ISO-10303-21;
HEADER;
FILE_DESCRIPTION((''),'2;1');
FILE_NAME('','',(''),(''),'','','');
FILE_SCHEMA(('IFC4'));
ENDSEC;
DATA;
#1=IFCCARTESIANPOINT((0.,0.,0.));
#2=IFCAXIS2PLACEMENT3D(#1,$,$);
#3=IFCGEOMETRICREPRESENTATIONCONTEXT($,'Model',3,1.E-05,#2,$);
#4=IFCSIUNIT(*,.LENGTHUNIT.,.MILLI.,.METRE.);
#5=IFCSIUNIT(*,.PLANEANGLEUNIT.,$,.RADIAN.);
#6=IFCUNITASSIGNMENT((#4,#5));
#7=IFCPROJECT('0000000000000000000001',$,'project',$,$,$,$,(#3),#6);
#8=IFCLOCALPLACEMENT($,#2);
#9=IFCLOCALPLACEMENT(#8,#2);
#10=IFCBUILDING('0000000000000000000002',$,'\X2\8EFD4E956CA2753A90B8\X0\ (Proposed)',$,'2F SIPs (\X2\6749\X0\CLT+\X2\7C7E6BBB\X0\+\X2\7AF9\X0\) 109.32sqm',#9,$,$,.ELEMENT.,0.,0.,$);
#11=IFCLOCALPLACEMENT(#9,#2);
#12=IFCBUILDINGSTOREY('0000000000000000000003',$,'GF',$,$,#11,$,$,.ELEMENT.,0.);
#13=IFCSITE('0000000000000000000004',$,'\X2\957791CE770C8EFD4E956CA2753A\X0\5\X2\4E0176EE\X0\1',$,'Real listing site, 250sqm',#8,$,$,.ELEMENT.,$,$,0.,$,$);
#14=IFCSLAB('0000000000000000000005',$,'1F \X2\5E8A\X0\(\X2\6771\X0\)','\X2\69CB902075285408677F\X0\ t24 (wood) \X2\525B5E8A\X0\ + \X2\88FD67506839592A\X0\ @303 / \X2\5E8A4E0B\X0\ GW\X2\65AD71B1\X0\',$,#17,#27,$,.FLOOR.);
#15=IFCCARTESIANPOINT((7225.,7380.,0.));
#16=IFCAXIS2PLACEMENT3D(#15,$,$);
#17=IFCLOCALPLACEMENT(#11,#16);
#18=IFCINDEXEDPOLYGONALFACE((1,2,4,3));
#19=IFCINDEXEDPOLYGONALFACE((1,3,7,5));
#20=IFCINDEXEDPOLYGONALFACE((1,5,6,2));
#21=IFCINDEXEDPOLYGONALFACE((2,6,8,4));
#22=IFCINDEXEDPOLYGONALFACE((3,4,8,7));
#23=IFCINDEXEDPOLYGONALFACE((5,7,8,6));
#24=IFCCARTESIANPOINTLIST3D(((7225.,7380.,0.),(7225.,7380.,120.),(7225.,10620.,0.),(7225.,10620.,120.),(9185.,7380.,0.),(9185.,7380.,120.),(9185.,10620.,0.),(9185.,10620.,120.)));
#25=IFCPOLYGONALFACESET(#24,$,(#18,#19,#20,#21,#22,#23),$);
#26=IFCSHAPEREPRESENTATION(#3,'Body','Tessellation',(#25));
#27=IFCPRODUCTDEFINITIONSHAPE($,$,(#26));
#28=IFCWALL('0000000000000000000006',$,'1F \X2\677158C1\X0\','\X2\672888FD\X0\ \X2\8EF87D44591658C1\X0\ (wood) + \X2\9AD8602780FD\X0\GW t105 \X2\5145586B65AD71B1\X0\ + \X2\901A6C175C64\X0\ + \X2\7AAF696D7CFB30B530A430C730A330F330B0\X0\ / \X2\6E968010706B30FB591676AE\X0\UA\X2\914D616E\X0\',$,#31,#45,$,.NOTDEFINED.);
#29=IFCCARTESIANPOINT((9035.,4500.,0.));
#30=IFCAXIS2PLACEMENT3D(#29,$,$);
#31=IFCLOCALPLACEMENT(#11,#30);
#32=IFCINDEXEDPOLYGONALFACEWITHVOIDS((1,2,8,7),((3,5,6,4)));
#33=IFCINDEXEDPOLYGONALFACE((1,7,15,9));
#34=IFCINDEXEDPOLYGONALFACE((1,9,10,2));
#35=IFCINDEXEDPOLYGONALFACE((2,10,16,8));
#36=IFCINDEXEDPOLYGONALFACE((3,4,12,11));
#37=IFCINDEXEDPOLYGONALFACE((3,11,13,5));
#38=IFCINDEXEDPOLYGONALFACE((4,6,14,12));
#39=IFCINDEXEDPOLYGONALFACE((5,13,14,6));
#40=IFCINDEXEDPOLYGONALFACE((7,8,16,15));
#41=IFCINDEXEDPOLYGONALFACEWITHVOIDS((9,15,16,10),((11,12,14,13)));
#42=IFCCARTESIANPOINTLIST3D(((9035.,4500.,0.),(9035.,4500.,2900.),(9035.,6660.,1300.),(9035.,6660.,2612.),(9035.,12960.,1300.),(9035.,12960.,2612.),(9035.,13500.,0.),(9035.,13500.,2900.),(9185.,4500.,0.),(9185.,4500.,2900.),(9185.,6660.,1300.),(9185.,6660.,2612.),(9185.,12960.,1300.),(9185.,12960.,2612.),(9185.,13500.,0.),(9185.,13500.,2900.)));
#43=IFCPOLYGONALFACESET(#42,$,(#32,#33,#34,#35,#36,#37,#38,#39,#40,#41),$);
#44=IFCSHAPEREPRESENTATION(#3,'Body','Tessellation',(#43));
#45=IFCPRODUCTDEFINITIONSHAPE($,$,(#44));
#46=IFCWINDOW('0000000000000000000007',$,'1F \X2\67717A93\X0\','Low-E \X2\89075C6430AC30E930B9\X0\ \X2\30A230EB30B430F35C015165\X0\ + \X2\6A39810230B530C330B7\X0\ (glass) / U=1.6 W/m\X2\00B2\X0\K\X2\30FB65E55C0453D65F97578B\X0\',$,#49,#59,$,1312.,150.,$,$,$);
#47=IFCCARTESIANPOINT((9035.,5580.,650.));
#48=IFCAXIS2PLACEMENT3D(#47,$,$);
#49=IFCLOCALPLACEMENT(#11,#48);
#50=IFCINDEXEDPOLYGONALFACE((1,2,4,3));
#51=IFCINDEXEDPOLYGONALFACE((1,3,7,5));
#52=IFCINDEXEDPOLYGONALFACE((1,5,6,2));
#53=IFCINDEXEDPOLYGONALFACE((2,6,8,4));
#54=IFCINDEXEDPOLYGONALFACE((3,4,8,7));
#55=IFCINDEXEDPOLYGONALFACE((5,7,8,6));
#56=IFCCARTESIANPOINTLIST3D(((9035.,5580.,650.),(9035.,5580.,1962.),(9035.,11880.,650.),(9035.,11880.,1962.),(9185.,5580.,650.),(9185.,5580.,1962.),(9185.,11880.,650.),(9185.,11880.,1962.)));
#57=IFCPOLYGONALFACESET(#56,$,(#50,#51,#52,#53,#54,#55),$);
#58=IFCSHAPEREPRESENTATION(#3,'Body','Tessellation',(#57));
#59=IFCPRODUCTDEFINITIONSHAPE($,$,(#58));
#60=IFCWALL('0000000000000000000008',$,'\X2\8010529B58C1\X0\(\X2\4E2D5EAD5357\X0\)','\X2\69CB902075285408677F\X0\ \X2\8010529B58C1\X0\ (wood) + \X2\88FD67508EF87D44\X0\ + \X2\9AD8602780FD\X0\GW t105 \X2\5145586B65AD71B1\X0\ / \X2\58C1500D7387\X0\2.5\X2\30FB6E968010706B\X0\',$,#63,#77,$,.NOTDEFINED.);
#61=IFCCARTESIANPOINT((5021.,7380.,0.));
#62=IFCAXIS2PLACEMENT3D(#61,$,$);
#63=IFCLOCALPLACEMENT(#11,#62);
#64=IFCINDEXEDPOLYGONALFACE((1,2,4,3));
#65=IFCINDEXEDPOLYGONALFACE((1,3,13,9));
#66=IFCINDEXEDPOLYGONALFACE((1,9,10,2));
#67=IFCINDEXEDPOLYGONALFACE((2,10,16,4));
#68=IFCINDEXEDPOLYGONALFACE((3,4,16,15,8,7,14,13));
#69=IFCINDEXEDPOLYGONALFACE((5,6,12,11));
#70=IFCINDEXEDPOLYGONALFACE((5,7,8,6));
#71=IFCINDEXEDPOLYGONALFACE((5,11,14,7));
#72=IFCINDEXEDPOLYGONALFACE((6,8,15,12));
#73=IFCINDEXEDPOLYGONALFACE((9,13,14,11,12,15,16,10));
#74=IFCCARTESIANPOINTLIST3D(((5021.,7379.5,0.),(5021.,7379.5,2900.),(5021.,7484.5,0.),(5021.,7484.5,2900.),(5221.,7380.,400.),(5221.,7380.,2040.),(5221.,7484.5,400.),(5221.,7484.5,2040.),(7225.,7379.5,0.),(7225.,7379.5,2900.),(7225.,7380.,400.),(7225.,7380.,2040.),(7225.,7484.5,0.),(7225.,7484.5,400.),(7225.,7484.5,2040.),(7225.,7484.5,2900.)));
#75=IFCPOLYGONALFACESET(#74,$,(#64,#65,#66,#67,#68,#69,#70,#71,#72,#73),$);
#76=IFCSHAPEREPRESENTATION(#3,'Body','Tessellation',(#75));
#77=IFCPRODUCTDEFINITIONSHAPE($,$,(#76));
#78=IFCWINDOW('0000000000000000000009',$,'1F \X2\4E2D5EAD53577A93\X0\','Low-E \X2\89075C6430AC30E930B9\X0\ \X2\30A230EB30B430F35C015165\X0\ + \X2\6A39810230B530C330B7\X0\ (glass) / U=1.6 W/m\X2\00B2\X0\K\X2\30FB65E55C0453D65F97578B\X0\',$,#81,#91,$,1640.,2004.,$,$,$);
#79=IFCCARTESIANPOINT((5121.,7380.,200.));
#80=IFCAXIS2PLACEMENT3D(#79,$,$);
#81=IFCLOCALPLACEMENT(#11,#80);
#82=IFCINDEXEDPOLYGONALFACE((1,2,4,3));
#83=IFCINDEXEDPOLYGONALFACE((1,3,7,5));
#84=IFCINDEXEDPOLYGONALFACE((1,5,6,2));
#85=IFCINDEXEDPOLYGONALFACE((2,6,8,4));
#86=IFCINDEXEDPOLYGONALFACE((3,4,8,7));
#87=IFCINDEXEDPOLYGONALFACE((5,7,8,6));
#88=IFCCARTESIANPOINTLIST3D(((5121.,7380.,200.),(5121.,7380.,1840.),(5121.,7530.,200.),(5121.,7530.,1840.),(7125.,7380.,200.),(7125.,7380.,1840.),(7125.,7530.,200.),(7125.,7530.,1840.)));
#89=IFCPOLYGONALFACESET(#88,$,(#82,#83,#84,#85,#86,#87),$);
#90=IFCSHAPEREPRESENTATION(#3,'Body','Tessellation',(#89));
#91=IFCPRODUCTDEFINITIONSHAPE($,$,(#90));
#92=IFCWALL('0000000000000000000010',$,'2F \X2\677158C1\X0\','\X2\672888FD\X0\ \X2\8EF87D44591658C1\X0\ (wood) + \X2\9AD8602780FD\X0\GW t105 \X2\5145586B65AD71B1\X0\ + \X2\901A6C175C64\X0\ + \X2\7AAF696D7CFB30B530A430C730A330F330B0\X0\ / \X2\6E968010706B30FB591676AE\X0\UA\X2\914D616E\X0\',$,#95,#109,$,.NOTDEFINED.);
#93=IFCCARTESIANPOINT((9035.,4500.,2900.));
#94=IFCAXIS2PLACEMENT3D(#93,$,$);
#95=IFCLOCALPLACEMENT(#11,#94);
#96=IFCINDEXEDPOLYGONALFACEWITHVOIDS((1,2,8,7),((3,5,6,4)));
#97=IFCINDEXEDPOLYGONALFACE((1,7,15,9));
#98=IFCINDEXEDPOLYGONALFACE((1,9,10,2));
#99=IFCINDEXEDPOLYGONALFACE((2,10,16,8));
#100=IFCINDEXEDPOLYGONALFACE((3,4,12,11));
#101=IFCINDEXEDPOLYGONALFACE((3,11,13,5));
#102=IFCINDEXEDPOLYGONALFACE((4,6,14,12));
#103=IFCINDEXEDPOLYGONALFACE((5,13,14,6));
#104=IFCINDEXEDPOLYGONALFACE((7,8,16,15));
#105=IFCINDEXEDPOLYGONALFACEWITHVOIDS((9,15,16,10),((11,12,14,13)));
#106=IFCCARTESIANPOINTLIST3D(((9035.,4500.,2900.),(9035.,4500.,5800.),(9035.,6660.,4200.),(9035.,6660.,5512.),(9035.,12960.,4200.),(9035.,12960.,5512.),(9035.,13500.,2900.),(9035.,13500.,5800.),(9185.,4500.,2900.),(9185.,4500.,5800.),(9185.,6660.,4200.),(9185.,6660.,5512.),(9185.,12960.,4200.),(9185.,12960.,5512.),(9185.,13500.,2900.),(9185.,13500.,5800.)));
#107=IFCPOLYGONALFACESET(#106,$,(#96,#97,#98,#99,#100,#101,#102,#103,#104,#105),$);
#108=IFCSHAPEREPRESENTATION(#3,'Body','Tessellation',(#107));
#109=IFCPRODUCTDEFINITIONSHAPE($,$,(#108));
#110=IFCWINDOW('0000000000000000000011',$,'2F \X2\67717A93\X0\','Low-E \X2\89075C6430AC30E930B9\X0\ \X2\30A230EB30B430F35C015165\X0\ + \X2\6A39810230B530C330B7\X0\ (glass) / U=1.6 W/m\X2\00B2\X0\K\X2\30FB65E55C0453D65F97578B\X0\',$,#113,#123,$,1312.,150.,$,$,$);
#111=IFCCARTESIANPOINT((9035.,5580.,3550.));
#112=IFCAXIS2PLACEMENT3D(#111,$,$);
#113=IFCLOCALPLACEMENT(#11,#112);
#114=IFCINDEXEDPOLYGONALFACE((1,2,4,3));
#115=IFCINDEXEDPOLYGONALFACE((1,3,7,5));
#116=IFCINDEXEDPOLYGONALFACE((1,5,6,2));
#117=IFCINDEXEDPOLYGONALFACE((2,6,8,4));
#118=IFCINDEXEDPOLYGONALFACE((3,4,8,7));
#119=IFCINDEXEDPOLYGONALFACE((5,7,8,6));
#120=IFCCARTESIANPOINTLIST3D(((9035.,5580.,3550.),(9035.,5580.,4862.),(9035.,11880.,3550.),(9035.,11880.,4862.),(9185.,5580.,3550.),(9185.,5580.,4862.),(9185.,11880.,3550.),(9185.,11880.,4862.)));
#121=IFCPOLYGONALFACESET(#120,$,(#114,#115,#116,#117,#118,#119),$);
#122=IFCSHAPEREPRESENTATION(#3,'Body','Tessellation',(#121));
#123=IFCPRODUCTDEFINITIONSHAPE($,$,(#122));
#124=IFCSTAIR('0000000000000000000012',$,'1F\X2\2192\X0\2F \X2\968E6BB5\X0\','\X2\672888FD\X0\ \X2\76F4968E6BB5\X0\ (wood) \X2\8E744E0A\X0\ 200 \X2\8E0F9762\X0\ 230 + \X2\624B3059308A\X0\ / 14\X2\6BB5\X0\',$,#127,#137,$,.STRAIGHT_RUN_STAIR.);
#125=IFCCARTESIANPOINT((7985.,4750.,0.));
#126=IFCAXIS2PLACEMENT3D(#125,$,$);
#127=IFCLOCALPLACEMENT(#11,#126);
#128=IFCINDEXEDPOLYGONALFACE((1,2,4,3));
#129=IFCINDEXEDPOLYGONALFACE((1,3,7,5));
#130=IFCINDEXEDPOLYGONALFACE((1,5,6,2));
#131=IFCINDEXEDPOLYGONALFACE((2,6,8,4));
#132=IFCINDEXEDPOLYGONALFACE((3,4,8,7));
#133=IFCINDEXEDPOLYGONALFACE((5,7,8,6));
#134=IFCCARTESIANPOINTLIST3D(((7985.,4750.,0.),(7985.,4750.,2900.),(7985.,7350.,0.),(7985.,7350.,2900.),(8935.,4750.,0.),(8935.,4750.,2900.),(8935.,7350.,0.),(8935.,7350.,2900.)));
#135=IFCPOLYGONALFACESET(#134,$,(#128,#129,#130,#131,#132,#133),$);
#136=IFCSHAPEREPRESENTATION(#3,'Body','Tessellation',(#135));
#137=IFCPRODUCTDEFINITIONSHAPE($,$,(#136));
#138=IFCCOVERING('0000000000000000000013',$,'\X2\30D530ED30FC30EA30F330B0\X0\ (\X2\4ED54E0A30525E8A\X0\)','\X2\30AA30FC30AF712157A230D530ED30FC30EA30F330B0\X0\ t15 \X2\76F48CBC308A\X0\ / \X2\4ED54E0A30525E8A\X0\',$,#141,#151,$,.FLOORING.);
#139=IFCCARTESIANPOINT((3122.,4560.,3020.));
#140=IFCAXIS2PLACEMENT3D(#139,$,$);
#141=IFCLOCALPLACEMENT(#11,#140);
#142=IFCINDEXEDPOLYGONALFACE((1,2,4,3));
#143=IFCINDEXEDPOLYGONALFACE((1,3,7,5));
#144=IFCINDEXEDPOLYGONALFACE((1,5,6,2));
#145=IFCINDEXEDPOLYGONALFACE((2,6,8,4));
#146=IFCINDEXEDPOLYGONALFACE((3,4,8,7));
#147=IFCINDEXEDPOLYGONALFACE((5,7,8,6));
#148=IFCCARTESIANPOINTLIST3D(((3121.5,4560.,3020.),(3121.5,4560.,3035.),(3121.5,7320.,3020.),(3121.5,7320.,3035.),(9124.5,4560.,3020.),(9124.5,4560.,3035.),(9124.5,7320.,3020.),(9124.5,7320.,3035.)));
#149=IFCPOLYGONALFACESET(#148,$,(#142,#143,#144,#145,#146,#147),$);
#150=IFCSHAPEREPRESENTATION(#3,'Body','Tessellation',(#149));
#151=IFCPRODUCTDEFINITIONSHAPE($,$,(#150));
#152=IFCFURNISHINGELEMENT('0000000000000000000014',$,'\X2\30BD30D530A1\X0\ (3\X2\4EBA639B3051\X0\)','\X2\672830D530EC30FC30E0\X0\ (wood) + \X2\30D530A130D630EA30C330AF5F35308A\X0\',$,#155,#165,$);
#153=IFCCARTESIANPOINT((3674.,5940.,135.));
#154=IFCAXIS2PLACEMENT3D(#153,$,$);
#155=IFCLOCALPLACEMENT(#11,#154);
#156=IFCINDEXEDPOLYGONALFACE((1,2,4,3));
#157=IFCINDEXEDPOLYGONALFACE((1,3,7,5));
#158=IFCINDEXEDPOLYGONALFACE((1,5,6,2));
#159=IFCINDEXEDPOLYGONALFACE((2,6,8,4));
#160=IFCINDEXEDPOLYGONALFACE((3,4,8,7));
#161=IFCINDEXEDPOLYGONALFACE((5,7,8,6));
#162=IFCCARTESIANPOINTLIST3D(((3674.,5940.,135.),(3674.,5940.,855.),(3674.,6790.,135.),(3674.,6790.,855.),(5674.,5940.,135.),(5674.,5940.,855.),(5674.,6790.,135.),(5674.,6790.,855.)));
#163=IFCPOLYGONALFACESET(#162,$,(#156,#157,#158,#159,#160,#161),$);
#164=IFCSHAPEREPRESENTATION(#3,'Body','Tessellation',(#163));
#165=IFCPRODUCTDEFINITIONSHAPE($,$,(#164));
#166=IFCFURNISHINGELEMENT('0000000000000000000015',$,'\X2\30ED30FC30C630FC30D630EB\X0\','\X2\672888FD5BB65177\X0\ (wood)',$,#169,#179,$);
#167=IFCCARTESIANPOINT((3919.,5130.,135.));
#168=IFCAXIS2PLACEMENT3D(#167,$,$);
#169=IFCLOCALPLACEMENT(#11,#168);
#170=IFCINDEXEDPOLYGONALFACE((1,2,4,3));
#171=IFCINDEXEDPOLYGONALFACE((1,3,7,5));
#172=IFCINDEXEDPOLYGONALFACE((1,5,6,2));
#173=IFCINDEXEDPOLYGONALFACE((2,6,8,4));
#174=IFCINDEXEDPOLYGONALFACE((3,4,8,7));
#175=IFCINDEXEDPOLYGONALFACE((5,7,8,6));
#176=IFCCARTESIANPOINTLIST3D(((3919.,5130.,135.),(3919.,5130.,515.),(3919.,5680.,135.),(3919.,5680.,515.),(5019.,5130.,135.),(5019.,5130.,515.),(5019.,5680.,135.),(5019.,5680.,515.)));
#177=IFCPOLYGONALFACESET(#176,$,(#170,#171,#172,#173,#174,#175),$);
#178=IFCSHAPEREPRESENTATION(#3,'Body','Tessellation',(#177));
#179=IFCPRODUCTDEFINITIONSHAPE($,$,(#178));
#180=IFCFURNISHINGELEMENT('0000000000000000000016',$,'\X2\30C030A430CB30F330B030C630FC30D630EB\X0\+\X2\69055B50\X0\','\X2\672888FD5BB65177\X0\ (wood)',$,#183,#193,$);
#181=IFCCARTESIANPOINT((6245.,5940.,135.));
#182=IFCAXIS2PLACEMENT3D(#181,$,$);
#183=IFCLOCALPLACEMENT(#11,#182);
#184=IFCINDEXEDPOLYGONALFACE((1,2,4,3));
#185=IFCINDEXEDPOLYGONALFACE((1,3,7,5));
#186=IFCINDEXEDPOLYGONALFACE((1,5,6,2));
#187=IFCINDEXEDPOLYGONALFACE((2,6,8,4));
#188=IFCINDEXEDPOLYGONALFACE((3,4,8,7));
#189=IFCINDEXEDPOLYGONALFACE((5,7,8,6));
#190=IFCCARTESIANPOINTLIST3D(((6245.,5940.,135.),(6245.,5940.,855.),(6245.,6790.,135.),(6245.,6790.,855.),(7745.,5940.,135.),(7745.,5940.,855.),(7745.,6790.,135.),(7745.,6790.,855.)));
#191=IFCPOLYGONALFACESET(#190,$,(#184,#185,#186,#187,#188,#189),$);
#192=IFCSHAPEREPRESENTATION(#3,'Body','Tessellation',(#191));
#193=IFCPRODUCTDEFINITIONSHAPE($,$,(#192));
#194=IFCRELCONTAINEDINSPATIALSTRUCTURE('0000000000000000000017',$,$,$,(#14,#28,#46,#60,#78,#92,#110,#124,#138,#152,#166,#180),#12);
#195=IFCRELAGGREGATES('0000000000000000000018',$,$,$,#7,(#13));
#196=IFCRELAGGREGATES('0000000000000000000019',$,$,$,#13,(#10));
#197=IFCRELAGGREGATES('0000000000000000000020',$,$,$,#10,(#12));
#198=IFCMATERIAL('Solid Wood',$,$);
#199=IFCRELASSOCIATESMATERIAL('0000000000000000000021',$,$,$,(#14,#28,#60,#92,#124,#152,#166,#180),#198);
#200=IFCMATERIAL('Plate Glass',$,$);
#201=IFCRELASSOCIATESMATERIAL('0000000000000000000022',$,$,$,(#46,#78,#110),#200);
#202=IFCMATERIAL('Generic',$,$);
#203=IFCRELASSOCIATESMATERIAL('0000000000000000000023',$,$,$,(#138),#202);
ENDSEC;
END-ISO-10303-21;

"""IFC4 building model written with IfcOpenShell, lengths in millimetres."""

from ifc_helpers import new_model, si_unit, frame, frame_2d, origin, place, context, project, spatial, rectangle, extrude, material, element, fill, save


model = new_model("IFC4")

# Units and contexts
model_context = context("Model", 3, precision=1e-05, world=origin())
ifc_project = project(units=[si_unit("LENGTHUNIT", "METRE", prefix="MILLI"), si_unit("PLANEANGLEUNIT", "RADIAN")], contexts=[model_context])

# Site, building, storey
site_placement = place(None, origin())
site = spatial("IfcSite", under=ifc_project, at=site_placement, Name="長野県軽井沢町5丁目1", ObjectType="Real listing site, 250sqm", CompositionType="ELEMENT", RefElevation=0.0)
building_placement = place(site_placement, origin())
building = spatial("IfcBuilding", under=site, at=building_placement, Name="軽井沢町邸 (Proposed)", ObjectType="2F SIPs (杉CLT+籾殻+竹) 109.32sqm", CompositionType="ELEMENT", ElevationOfRefHeight=0.0, ElevationOfTerrain=0.0)
storey_placement = place(building_placement, origin())
storey = spatial("IfcBuildingStorey", under=building, at=storey_placement, Name="GF", CompositionType="ELEMENT", Elevation=0.0)

# Slab
ifc_material_1 = material(Name="Solid Wood")
slab_placement = place(storey_placement, frame((7225.0, 7380.0, 0.0)))
element("IfcSlab", 1, at=slab_placement, inside=storey, material=ifc_material_1, Name="1F 床(東)", Description="構造用合板 t24 (wood) 剛床 + 製材根太 @303 / 床下 GW断熱", PredefinedType="FLOOR", context=model_context, shape_type="SweptSolid", body=[
    extrude(rectangle(XDim=1960.0, YDim=3240.0, at=frame_2d((980.0, 1620.0))), frame((7225.0, 7380.0, 0.0)), (0.0, 0.0, 1.0), 120.0),
])

# Walls, openings, windows
wall_1_placement = place(storey_placement, frame((9035.0, 4500.0, 0.0)))
wall_1 = element("IfcWall", 2, at=wall_1_placement, inside=storey, material=ifc_material_1, Name="1F 東壁", Description="木製 軸組外壁 (wood) + 高性能GW t105 充填断熱 + 通気層 + 窯業系サイディング / 準耐火・外皮UA配慮", PredefinedType="NOTDEFINED", context=model_context, shape_type="SweptSolid", body=[
    extrude(rectangle(XDim=150.0, YDim=9000.0, at=frame_2d((75.0, 4500.0))), frame((9035.0, 4500.0, 0.0)), (0.0, 0.0, 1.0), 2900.0),
])
opening_1_placement = place(storey_placement, frame((9035.0, 5580.0, 650.0)))
opening_1 = element("IfcOpeningElement", 3, at=opening_1_placement, cuts=wall_1, PredefinedType="NOTDEFINED", context=model_context, shape_type="SweptSolid", body=[
    extrude(rectangle(XDim=150.0, YDim=6300.0, at=frame_2d((75.0, 3150.0))), frame((9035.0, 5580.0, 650.0)), (0.0, 0.0, 1.0), 1312.0),
])
ifc_material_2 = material(Name="Plate Glass")
window_1_placement = place(storey_placement, frame((9035.0, 5580.0, 650.0)))
window_1 = element("IfcWindow", 4, at=window_1_placement, inside=storey, material=ifc_material_2, Name="1F 東窓", Description="Low-E 複層ガラス アルゴン封入 + 樹脂サッシ (glass) / U=1.6 W/m²K・日射取得型", OverallHeight=1312.0, OverallWidth=150.0, context=model_context, shape_type="SweptSolid", body=[
    extrude(rectangle(XDim=150.0, YDim=6300.0, at=frame_2d((75.0, 3150.0))), frame((9035.0, 5580.0, 650.0)), (0.0, 0.0, 1.0), 1312.0),
])
fill(opening_1, window_1)
wall_2_placement = place(storey_placement, frame((5021.0, 7380.0, 0.0)))
wall_2 = element("IfcWall", 5, at=wall_2_placement, inside=storey, material=ifc_material_1, Name="耐力壁(中庭南)", Description="構造用合板 耐力壁 (wood) + 製材軸組 + 高性能GW t105 充填断熱 / 壁倍率2.5・準耐火", PredefinedType="NOTDEFINED", context=model_context, shape_type="SweptSolid", body=[
    extrude(rectangle(XDim=2204.0, YDim=105.0, at=frame_2d((1102.0, 52.0))), frame((5021.0, 7380.0, 0.0)), (0.0, 0.0, 1.0), 2900.0),
])
opening_2_placement = place(storey_placement, frame((5121.0, 7380.0, 200.0)))
opening_2 = element("IfcOpeningElement", 6, at=opening_2_placement, cuts=wall_2, PredefinedType="NOTDEFINED", context=model_context, shape_type="SweptSolid", body=[
    extrude(rectangle(XDim=2004.0, YDim=150.0, at=frame_2d((1002.0, 75.0))), frame((5121.0, 7380.0, 200.0)), (0.0, 0.0, 1.0), 1640.0),
])
window_2_placement = place(storey_placement, frame((5121.0, 7380.0, 200.0)))
window_2 = element("IfcWindow", 7, at=window_2_placement, inside=storey, material=ifc_material_2, Name="1F 中庭南窓", Description="Low-E 複層ガラス アルゴン封入 + 樹脂サッシ (glass) / U=1.6 W/m²K・日射取得型", OverallHeight=1640.0, OverallWidth=2004.0, context=model_context, shape_type="SweptSolid", body=[
    extrude(rectangle(XDim=2004.0, YDim=150.0, at=frame_2d((1002.0, 75.0))), frame((5121.0, 7380.0, 200.0)), (0.0, 0.0, 1.0), 1640.0),
])
fill(opening_2, window_2)

# Wall, opening, window
wall_3_placement = place(storey_placement, frame((9035.0, 4500.0, 2900.0)))
wall_3 = element("IfcWall", 8, at=wall_3_placement, inside=storey, material=ifc_material_1, Name="2F 東壁", Description="木製 軸組外壁 (wood) + 高性能GW t105 充填断熱 + 通気層 + 窯業系サイディング / 準耐火・外皮UA配慮", PredefinedType="NOTDEFINED", context=model_context, shape_type="SweptSolid", body=[
    extrude(rectangle(XDim=150.0, YDim=9000.0, at=frame_2d((75.0, 4500.0))), frame((9035.0, 4500.0, 2900.0)), (0.0, 0.0, 1.0), 2900.0),
])
opening_3_placement = place(storey_placement, frame((9035.0, 5580.0, 3550.0)))
opening_3 = element("IfcOpeningElement", 9, at=opening_3_placement, cuts=wall_3, PredefinedType="NOTDEFINED", context=model_context, shape_type="SweptSolid", body=[
    extrude(rectangle(XDim=150.0, YDim=6300.0, at=frame_2d((75.0, 3150.0))), frame((9035.0, 5580.0, 3550.0)), (0.0, 0.0, 1.0), 1312.0),
])
window_3_placement = place(storey_placement, frame((9035.0, 5580.0, 3550.0)))
window_3 = element("IfcWindow", 10, at=window_3_placement, inside=storey, material=ifc_material_2, Name="2F 東窓", Description="Low-E 複層ガラス アルゴン封入 + 樹脂サッシ (glass) / U=1.6 W/m²K・日射取得型", OverallHeight=1312.0, OverallWidth=150.0, context=model_context, shape_type="SweptSolid", body=[
    extrude(rectangle(XDim=150.0, YDim=6300.0, at=frame_2d((75.0, 3150.0))), frame((9035.0, 5580.0, 3550.0)), (0.0, 0.0, 1.0), 1312.0),
])
fill(opening_3, window_3)

# Stair
stair_placement = place(storey_placement, frame((7985.0, 4750.0, 0.0)))
element("IfcStair", 11, at=stair_placement, inside=storey, material=ifc_material_1, Name="1F→2F 階段", Description="木製 直階段 (wood) 蹴上 200 踏面 230 + 手すり / 14段", PredefinedType="STRAIGHT_RUN_STAIR", context=model_context, shape_type="SweptSolid", body=[
    extrude(rectangle(XDim=950.0, YDim=2600.0, at=frame_2d((475.0, 1300.0))), frame((7985.0, 4750.0, 0.0)), (0.0, 0.0, 1.0), 2900.0),
])

# Covering
ifc_material_3 = material(Name="Generic")
covering_placement = place(storey_placement, frame((3122.0, 4560.0, 3020.0)))
element("IfcCovering", 12, at=covering_placement, inside=storey, material=ifc_material_3, Name="フローリング (仕上げ床)", Description="オーク無垢フローリング t15 直貼り / 仕上げ床", PredefinedType="FLOORING", context=model_context, shape_type="SweptSolid", body=[
    extrude(rectangle(XDim=6003.0, YDim=2760.0, at=frame_2d((3001.0, 1380.0))), frame((3122.0, 4560.0, 3020.0)), (0.0, 0.0, 1.0), 15.0),
])

# Furnishing elements
furnishing_1_placement = place(storey_placement, frame((3674.0, 5940.0, 135.0)))
element("IfcFurnishingElement", 13, at=furnishing_1_placement, inside=storey, material=ifc_material_1, Name="ソファ (3人掛け)", Description="木フレーム (wood) + ファブリック張り", context=model_context, shape_type="SweptSolid", body=[
    extrude(rectangle(XDim=2000.0, YDim=850.0, at=frame_2d((1000.0, 425.0))), frame((3674.0, 5940.0, 135.0)), (0.0, 0.0, 1.0), 720.0),
])
furnishing_2_placement = place(storey_placement, frame((3919.0, 5130.0, 135.0)))
element("IfcFurnishingElement", 14, at=furnishing_2_placement, inside=storey, material=ifc_material_1, Name="ローテーブル", Description="木製家具 (wood)", context=model_context, shape_type="SweptSolid", body=[
    extrude(rectangle(XDim=1100.0, YDim=550.0, at=frame_2d((550.0, 275.0))), frame((3919.0, 5130.0, 135.0)), (0.0, 0.0, 1.0), 380.0),
])
furnishing_3_placement = place(storey_placement, frame((6245.0, 5940.0, 135.0)))
element("IfcFurnishingElement", 15, at=furnishing_3_placement, inside=storey, material=ifc_material_1, Name="ダイニングテーブル+椅子", Description="木製家具 (wood)", context=model_context, shape_type="SweptSolid", body=[
    extrude(rectangle(XDim=1500.0, YDim=850.0, at=frame_2d((750.0, 425.0))), frame((6245.0, 5940.0, 135.0)), (0.0, 0.0, 1.0), 720.0),
])

save(model, "model.ifc")
